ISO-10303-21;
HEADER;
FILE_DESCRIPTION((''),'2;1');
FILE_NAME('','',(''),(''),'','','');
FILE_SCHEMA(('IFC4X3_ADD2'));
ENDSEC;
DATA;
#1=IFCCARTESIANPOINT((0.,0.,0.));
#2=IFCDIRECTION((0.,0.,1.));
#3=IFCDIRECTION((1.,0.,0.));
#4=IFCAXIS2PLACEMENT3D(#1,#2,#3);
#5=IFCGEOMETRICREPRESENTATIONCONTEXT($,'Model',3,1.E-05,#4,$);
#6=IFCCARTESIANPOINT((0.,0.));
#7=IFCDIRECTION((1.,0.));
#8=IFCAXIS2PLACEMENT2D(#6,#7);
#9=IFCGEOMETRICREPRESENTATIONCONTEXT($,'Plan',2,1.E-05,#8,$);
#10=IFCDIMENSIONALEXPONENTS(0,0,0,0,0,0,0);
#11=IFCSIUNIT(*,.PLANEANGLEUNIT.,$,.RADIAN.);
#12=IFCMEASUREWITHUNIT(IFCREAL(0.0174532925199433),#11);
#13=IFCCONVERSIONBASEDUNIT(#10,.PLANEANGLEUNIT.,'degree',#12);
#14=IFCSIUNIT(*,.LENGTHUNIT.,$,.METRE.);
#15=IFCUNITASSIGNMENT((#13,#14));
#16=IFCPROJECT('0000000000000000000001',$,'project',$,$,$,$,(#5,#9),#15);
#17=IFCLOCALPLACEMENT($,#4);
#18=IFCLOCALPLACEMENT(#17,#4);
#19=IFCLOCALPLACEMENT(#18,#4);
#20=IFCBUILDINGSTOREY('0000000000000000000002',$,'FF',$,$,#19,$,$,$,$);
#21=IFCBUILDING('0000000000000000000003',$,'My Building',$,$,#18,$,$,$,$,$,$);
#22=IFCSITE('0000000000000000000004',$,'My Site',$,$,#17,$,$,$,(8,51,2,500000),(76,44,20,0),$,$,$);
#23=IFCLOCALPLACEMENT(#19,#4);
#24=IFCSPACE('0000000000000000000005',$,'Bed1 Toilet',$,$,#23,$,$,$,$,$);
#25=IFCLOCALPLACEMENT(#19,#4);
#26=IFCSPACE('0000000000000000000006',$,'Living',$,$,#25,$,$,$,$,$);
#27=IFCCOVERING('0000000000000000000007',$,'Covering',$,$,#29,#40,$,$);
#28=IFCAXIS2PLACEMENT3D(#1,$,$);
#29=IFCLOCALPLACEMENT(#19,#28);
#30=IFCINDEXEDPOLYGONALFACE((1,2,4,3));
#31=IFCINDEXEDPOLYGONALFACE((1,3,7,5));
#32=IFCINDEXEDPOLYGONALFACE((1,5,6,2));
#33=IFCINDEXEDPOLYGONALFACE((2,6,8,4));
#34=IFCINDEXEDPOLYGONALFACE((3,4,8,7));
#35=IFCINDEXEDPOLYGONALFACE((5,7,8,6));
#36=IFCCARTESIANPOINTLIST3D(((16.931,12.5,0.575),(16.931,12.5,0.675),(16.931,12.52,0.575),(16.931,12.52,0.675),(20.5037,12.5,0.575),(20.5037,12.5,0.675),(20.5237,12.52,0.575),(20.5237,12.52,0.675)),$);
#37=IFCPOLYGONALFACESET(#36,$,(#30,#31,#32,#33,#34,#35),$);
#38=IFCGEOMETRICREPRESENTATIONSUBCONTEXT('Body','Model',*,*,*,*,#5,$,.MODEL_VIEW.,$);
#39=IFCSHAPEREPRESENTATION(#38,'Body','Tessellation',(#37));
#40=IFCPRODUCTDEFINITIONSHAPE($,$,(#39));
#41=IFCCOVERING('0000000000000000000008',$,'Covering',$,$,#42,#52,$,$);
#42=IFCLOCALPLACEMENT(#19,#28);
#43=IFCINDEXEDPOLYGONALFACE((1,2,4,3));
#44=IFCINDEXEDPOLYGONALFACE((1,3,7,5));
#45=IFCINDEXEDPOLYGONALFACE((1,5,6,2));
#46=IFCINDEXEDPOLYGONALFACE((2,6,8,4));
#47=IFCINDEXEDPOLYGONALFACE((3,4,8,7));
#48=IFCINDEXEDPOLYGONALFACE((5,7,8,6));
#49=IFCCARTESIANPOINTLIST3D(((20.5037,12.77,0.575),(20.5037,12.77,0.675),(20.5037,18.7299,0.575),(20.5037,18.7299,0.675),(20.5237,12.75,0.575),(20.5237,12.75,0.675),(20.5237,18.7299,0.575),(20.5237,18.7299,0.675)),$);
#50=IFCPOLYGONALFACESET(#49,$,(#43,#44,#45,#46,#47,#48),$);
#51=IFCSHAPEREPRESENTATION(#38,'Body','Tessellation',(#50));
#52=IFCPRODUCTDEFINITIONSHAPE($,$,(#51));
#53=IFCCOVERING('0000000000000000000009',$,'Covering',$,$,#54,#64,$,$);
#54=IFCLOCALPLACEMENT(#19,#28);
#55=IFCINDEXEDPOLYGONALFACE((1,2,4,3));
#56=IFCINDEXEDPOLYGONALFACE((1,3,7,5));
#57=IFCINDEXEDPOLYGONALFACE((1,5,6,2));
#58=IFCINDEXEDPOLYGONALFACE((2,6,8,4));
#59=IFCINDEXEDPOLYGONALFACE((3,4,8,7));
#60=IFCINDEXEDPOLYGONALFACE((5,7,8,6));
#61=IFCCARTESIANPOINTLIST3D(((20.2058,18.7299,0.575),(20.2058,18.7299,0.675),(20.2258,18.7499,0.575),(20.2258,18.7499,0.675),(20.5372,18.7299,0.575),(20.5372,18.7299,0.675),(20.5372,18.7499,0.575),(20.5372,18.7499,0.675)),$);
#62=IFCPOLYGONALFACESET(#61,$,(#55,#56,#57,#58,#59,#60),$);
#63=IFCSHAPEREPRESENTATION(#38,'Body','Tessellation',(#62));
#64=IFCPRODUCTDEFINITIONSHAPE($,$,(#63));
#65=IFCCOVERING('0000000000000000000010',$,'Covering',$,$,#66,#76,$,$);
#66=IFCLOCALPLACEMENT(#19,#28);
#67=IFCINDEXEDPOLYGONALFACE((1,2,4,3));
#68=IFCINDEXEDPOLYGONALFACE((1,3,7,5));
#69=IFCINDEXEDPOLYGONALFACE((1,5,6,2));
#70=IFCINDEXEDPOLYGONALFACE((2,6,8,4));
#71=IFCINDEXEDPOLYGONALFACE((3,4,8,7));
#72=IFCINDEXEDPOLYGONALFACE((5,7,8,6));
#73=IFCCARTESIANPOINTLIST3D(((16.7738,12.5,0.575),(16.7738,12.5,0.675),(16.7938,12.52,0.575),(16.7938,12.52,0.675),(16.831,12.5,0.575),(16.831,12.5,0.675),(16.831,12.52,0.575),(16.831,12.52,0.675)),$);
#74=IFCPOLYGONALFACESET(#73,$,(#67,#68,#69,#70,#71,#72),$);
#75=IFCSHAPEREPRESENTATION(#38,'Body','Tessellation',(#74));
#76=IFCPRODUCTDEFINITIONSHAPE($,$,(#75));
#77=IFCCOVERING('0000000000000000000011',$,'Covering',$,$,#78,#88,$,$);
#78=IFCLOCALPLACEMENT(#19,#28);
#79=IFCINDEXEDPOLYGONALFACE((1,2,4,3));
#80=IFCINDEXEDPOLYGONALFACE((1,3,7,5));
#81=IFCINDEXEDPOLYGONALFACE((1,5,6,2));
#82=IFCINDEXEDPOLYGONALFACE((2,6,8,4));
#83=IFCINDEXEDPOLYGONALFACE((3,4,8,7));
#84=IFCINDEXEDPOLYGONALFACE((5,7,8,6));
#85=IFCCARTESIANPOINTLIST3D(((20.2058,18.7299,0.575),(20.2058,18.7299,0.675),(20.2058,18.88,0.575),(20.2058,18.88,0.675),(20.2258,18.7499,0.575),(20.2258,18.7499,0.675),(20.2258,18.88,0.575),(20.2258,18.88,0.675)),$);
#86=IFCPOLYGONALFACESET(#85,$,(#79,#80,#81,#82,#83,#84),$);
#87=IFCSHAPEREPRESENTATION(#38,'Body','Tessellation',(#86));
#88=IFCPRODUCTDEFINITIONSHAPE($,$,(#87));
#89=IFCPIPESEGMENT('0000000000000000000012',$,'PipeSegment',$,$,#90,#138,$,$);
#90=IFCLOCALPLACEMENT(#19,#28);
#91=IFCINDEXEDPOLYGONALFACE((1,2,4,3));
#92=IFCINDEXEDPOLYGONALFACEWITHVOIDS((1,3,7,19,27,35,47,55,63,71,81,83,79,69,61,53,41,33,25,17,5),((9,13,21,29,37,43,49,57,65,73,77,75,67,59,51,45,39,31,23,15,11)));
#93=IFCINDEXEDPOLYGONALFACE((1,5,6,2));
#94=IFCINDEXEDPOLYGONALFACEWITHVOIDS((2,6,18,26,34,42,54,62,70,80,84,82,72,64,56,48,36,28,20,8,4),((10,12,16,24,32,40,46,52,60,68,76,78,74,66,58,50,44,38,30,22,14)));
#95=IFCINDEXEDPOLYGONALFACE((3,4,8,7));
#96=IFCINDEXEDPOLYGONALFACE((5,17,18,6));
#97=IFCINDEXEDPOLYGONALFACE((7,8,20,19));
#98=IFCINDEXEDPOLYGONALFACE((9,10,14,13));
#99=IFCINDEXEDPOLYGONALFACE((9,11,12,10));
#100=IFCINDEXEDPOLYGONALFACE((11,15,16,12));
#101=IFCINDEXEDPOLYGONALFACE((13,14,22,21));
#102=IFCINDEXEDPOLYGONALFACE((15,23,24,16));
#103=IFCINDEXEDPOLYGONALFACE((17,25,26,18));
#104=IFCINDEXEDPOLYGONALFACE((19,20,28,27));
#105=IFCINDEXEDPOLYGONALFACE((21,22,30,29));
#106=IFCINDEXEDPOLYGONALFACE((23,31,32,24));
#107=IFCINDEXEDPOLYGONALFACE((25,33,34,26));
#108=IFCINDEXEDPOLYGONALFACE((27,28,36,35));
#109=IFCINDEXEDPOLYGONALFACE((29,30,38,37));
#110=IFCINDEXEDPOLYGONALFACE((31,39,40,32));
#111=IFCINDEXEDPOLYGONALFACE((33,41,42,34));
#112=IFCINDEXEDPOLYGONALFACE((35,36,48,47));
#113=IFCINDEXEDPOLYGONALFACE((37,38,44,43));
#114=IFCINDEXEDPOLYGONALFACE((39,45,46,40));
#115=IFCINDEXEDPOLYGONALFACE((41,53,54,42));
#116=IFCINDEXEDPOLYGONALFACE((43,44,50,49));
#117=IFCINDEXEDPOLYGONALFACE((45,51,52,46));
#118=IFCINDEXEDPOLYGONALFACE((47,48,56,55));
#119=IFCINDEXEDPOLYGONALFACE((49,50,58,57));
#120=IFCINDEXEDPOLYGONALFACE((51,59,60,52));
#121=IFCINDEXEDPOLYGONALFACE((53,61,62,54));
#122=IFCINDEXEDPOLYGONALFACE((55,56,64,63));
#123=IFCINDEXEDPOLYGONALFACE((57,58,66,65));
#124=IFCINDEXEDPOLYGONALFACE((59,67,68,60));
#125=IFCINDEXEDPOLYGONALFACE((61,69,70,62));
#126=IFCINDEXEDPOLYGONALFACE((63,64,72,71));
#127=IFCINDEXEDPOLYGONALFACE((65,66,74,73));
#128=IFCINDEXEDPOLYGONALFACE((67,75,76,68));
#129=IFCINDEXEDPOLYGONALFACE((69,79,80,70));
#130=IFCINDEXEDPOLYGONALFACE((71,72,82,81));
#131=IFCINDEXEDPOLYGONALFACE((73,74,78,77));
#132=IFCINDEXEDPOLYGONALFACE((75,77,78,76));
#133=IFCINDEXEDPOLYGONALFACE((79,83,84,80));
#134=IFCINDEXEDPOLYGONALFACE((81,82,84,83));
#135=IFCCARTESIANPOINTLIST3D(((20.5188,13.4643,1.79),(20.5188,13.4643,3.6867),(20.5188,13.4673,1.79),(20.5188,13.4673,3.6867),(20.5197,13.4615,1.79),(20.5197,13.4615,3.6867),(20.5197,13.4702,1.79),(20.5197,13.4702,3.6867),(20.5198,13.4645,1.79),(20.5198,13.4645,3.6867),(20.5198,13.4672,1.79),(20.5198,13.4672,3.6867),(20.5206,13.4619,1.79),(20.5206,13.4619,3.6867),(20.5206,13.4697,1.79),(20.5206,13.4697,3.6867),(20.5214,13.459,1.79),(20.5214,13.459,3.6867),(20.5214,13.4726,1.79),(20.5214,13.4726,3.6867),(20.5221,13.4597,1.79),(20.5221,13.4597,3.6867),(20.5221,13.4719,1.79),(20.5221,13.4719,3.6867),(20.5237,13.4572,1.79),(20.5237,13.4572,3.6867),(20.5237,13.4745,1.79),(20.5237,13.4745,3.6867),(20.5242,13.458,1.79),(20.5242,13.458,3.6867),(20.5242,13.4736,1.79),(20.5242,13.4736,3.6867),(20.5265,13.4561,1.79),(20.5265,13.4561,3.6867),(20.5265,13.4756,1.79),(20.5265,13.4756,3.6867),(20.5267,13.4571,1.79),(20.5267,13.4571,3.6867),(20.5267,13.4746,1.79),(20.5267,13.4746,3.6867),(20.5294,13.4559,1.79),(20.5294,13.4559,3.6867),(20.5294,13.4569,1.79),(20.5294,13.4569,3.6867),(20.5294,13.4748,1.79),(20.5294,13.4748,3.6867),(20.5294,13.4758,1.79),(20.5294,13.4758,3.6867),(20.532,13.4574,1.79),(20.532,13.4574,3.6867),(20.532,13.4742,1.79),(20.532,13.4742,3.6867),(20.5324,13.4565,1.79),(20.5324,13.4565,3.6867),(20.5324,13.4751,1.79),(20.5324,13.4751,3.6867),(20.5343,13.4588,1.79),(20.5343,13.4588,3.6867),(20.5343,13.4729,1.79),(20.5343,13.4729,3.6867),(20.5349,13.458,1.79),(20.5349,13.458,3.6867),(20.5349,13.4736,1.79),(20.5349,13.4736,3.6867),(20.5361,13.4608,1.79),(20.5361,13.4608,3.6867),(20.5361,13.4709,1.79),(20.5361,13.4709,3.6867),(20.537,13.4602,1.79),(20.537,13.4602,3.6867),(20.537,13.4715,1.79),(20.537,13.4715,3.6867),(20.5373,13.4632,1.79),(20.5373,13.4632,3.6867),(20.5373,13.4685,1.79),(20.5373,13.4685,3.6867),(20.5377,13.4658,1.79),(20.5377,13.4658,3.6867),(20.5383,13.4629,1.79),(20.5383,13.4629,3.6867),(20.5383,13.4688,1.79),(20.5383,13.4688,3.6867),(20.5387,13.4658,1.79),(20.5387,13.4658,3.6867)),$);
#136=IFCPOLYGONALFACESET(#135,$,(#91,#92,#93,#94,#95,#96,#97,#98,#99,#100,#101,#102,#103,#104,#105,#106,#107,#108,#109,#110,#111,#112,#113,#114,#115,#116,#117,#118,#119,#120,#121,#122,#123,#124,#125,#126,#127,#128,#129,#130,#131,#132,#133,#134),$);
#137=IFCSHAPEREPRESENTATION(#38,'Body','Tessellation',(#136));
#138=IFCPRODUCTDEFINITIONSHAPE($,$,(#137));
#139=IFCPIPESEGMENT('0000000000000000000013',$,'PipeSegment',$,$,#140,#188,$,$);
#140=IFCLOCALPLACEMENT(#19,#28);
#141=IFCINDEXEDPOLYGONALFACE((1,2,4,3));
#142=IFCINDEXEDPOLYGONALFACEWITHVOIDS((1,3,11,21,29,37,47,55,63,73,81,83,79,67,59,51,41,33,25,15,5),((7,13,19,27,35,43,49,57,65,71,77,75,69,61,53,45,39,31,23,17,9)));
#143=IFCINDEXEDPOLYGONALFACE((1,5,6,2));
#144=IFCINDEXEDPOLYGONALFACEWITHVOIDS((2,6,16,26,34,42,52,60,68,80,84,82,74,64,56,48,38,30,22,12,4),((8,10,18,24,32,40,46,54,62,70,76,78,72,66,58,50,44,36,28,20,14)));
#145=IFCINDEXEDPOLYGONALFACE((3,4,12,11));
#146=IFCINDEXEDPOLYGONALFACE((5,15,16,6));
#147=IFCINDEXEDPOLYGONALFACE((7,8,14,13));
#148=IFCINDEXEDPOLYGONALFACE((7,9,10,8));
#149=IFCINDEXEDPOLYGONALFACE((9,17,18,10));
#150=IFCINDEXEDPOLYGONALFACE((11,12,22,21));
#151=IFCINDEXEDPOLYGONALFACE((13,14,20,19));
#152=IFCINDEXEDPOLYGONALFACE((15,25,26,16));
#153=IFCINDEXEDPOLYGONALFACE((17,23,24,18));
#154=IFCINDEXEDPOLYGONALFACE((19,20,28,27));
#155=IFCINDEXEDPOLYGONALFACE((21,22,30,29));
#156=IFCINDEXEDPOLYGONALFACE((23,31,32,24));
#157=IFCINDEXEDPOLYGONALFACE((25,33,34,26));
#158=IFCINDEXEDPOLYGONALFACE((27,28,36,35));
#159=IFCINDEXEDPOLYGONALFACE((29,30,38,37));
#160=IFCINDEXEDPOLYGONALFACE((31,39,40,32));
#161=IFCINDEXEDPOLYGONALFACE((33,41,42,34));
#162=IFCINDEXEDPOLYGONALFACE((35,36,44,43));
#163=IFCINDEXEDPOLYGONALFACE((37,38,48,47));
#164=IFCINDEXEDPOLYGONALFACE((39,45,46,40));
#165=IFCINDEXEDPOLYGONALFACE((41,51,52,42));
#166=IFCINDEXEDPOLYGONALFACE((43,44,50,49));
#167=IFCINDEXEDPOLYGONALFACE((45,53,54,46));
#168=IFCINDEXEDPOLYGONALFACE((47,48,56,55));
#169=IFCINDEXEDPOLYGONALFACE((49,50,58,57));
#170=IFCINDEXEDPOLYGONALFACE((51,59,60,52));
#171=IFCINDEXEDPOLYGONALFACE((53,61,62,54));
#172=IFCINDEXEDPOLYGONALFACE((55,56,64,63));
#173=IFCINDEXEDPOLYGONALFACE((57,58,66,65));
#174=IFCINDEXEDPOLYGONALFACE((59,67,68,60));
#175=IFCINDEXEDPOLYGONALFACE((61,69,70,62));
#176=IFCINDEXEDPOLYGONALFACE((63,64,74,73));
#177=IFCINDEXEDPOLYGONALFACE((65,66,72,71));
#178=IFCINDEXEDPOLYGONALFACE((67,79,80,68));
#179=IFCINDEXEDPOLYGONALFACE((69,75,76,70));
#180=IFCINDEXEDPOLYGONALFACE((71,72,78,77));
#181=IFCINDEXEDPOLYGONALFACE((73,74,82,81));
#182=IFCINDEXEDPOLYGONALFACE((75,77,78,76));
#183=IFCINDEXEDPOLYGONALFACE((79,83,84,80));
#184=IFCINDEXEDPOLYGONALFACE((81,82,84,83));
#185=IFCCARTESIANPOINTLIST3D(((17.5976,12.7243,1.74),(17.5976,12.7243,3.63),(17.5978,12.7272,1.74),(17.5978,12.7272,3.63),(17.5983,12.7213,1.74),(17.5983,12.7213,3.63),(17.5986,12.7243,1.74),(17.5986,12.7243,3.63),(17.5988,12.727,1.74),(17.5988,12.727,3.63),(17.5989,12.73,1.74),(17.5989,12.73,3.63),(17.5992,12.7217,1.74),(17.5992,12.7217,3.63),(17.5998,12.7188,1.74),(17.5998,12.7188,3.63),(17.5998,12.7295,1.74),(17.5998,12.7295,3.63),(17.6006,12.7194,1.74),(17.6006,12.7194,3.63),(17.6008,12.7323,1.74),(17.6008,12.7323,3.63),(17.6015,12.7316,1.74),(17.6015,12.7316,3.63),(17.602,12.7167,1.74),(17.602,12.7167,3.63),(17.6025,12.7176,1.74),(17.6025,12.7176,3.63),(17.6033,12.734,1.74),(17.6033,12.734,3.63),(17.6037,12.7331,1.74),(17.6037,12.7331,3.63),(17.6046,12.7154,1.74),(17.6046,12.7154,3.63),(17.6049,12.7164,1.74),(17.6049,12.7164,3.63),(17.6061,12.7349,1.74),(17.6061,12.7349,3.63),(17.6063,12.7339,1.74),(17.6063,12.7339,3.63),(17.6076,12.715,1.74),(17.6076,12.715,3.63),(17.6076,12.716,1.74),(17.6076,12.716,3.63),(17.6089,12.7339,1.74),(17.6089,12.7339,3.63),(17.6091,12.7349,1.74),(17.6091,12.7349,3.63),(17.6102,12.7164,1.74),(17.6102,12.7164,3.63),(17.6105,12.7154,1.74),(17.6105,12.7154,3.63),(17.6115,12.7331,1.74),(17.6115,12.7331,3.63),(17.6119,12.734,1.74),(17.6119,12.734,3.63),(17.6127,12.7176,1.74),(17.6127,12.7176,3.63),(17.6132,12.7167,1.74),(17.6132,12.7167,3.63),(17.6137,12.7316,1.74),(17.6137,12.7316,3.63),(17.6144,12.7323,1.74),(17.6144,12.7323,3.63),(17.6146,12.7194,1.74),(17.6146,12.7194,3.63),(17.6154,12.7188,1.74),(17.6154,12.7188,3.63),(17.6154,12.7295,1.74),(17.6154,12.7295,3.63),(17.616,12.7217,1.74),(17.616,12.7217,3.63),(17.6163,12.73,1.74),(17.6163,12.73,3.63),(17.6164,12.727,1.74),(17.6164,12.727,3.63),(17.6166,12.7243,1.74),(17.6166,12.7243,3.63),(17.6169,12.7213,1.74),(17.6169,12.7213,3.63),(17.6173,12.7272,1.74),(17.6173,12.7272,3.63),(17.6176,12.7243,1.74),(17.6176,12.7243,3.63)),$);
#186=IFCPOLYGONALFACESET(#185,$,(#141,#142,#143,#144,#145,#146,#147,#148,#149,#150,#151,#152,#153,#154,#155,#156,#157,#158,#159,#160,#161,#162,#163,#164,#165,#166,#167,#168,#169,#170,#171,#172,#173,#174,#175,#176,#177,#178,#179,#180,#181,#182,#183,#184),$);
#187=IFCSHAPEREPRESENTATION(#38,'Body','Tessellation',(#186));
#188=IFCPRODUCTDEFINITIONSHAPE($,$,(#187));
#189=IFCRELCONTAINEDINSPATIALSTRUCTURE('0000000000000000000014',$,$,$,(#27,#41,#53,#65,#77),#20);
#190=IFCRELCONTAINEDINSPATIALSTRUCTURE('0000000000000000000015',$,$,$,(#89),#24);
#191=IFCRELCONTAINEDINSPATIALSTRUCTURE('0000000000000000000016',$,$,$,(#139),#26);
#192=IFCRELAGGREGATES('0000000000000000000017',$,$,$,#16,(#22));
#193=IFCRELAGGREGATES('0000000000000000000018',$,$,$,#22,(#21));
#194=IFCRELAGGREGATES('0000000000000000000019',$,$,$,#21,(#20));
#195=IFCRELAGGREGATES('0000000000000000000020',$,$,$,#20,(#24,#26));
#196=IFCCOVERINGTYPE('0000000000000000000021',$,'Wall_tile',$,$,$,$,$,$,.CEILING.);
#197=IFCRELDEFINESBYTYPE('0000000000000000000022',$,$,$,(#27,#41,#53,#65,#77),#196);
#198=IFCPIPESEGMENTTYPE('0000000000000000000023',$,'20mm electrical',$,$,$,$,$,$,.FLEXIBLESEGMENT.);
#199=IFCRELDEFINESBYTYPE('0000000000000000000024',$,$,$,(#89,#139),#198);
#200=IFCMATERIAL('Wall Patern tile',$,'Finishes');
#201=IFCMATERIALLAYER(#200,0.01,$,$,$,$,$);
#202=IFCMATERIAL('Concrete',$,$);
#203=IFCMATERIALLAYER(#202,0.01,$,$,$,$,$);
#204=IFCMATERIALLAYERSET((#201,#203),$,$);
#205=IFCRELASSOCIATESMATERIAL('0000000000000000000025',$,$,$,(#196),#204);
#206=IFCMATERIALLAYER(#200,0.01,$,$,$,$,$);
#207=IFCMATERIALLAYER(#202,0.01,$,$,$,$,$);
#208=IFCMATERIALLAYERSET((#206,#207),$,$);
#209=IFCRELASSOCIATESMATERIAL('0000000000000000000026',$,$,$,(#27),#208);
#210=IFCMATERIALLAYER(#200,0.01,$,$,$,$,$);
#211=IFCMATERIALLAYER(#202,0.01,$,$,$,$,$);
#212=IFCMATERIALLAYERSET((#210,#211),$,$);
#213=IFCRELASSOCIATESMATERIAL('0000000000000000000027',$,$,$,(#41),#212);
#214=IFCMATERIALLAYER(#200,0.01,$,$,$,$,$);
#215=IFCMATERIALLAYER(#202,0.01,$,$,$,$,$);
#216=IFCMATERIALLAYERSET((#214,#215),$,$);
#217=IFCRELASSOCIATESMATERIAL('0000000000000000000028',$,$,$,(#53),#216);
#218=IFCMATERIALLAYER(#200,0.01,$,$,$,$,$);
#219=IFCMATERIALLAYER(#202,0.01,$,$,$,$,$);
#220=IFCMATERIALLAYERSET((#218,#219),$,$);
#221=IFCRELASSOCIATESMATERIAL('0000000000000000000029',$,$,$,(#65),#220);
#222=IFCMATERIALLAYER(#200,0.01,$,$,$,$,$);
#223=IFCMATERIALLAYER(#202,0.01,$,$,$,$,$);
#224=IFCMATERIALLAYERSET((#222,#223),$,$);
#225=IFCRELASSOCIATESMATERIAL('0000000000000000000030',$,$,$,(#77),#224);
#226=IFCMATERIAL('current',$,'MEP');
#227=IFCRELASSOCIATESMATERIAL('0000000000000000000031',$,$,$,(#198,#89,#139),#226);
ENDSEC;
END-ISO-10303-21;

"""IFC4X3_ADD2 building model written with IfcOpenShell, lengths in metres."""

from ifc_helpers import new_model, entity, si_unit, converted_unit, frame, origin_with_axes, origin_2d_with_axis, place, context, subcontext, project, spatial, line, indexed_curve, hollow_circle, outline, extrude, material, layer, layer_set, layer_usage, material_profile, profile_set, profile_usage, type_object, element, save


model = new_model("IFC4X3_ADD2")

# Units and contexts
model_context = context("Model", 3, precision=1e-05, world=origin_with_axes())
plan_context = context("Plan", 2, precision=1e-05, world=origin_2d_with_axis())
body_context_1 = subcontext(model_context, "Body", "Model", "MODEL_VIEW")
ifc_project = project(units=[converted_unit("PLANEANGLEUNIT", "degree", entity("IfcReal", 0.0174532925199433), si_unit("PLANEANGLEUNIT", "RADIAN"), dimensions=[0, 0, 0, 0, 0, 0, 0]), si_unit("LENGTHUNIT", "METRE")], contexts=[model_context, plan_context])

# Site, building, storey
site_placement = place(None, origin_with_axes())
site = spatial("IfcSite", under=ifc_project, at=site_placement, Name="My Site", RefLatitude=(8, 51, 2, 500000), RefLongitude=(76, 44, 20, 0))
building_placement = place(site_placement, origin_with_axes())
building = spatial("IfcBuilding", under=site, at=building_placement, Name="My Building")
storey_placement = place(building_placement, origin_with_axes())
storey = spatial("IfcBuildingStorey", under=building, at=storey_placement, Name="FF")

# Coverings
ifc_material_1 = material(Name="Wall Patern tile", Category="Finishes")
ifc_material_2 = material(Name="Concrete")
ifc_layer_1 = layer(ifc_material_1, 0.01)
ifc_layer_2 = layer(ifc_material_2, 0.01)
ifc_layer_set_1 = layer_set([ifc_layer_1, ifc_layer_2])
covering_type = type_object("IfcCoveringType", Name="Wall_tile", PredefinedType="CEILING", material=ifc_layer_set_1)
ifc_layer_3 = layer(ifc_material_1, 0.01)
ifc_layer_4 = layer(ifc_material_2, 0.01)
ifc_layer_set_2 = layer_set([ifc_layer_3, ifc_layer_4])
ifc_layer_usage_1 = layer_usage(ifc_layer_set_2, "AXIS2", "POSITIVE", 0.0)
covering_1_placement = place(storey_placement, frame((16.931, 12.5, 0.575), z_axis=(0.0, 0.0, 1.0), x_axis=(1.0, 0.0, 0.0)))
element("IfcCovering", 1, at=covering_1_placement, inside=storey, type_object=covering_type, material=ifc_layer_usage_1, Name="Covering", context=body_context_1, shape_type="SweptSolid", body=[
    extrude(outline(indexed_curve([(0.0, 0.0), (0.0, 0.02), (3.5927, 0.02), (3.5727, 0.0)], segments=[line(1, 2, 3, 4, 1)])), origin_with_axes(), (0.0, 0.0, 1.0), 0.1),
])
ifc_layer_5 = layer(ifc_material_1, 0.01)
ifc_layer_6 = layer(ifc_material_2, 0.01)
ifc_layer_set_3 = layer_set([ifc_layer_5, ifc_layer_6])
ifc_layer_usage_2 = layer_usage(ifc_layer_set_3, "AXIS2", "POSITIVE", 0.0)
covering_2_placement = place(storey_placement, frame((20.5037, 18.7299, 0.575), z_axis=(0.0, 0.0, 1.0), x_axis=(0.0, -1.0, 0.0)))
element("IfcCovering", 2, at=covering_2_placement, inside=storey, type_object=covering_type, material=ifc_layer_usage_2, Name="Covering", context=body_context_1, shape_type="SweptSolid", body=[
    extrude(outline(indexed_curve([(0.0, 0.0), (0.0, 0.02), (5.9799, 0.02), (5.9599, 0.0)], segments=[line(1, 2, 3, 4, 1)])), origin_with_axes(), (0.0, 0.0, 1.0), 0.1),
])
ifc_layer_7 = layer(ifc_material_1, 0.01)
ifc_layer_8 = layer(ifc_material_2, 0.01)
ifc_layer_set_4 = layer_set([ifc_layer_7, ifc_layer_8])
ifc_layer_usage_3 = layer_usage(ifc_layer_set_4, "AXIS2", "POSITIVE", 0.0)
covering_3_placement = place(storey_placement, frame((20.2258, 18.7299, 0.575), z_axis=(0.0, 0.0, 1.0), x_axis=(1.0, 0.0, 0.0)))
element("IfcCovering", 3, at=covering_3_placement, inside=storey, type_object=covering_type, material=ifc_layer_usage_3, Name="Covering", context=body_context_1, shape_type="SweptSolid", body=[
    extrude(outline(indexed_curve([(-0.02, 0.0), (0.0, 0.02), (0.3114, 0.02), (0.3114, 0.0)], segments=[line(1, 2, 3, 4, 1)])), origin_with_axes(), (0.0, 0.0, 1.0), 0.1),
])
ifc_layer_9 = layer(ifc_material_1, 0.01)
ifc_layer_10 = layer(ifc_material_2, 0.01)
ifc_layer_set_5 = layer_set([ifc_layer_9, ifc_layer_10])
ifc_layer_usage_4 = layer_usage(ifc_layer_set_5, "AXIS2", "POSITIVE", 0.0)
covering_4_placement = place(storey_placement, frame((16.7738, 12.5, 0.575), z_axis=(0.0, 0.0, 1.0), x_axis=(1.0, 0.0, 0.0)))
element("IfcCovering", 4, at=covering_4_placement, inside=storey, type_object=covering_type, material=ifc_layer_usage_4, Name="Covering", context=body_context_1, shape_type="SweptSolid", body=[
    extrude(outline(indexed_curve([(0.0, 0.0), (0.02, 0.02), (0.0572, 0.02), (0.0572, 0.0)], segments=[line(1, 2, 3, 4, 1)])), origin_with_axes(), (0.0, 0.0, 1.0), 0.1),
])
ifc_layer_11 = layer(ifc_material_1, 0.01)
ifc_layer_12 = layer(ifc_material_2, 0.01)
ifc_layer_set_6 = layer_set([ifc_layer_11, ifc_layer_12])
ifc_layer_usage_5 = layer_usage(ifc_layer_set_6, "AXIS2", "NEGATIVE", 0.0)
covering_5_placement = place(storey_placement, frame((20.2058, 18.7299, 0.575), z_axis=(0.0, 0.0, 1.0), x_axis=(0.0, 1.0, 0.0)))
element("IfcCovering", 5, at=covering_5_placement, inside=storey, type_object=covering_type, material=ifc_layer_usage_5, Name="Covering", context=body_context_1, shape_type="SweptSolid", body=[
    extrude(outline(indexed_curve([(0.02, -0.02), (0.0, 0.0), (0.1501, 0.0), (0.1501, -0.02)], segments=[line(1, 2, 3, 4, 1)])), origin_with_axes(), (0.0, 0.0, 1.0), 0.1),
])

# Shared definitions
space_1_placement = place(storey_placement, origin_with_axes())
space_1 = spatial("IfcSpace", under=storey, at=space_1_placement, Name="Bed1 Toilet")

# Pipe segment
ifc_material_3 = material(Name="current", Category="MEP")
ifc_material_profile_1 = material_profile(ifc_material_3, hollow_circle(Radius=0.01, WallThickness=0.001))
ifc_profile_set_1 = profile_set([ifc_material_profile_1], Name="current")
ifc_profile_usage_1 = profile_usage(ifc_profile_set_1, cardinal=5)
pipe_segment_type = type_object("IfcPipeSegmentType", Name="20mm electrical", PredefinedType="FLEXIBLESEGMENT", material=ifc_profile_set_1)
pipe_segment_1_placement = place(space_1_placement, frame((20.5287, 13.4658, 1.79), z_axis=(0.0, 0.0, 1.0), x_axis=(1.0, 0.0, 0.0)))
element("IfcPipeSegment", 6, at=pipe_segment_1_placement, inside=space_1, type_object=pipe_segment_type, material=ifc_profile_usage_1, Name="PipeSegment", context=body_context_1, shape_type="SweptSolid", body=[
    extrude(hollow_circle(Radius=0.01, WallThickness=0.001), origin_with_axes(), (0.0, 0.0, 1.0), 1.8967),
])

# Shared definitions
space_2_placement = place(storey_placement, origin_with_axes())
space_2 = spatial("IfcSpace", under=storey, at=space_2_placement, Name="Living")

# Pipe segment
ifc_profile_usage_2 = profile_usage(ifc_profile_set_1, cardinal=5)
pipe_segment_2_placement = place(space_2_placement, frame((17.6076, 12.725, 1.74), z_axis=(0.0, 0.0, 1.0), x_axis=(0.0, -1.0, 0.0)))
element("IfcPipeSegment", 7, at=pipe_segment_2_placement, inside=space_2, type_object=pipe_segment_type, material=ifc_profile_usage_2, Name="PipeSegment", context=body_context_1, shape_type="SweptSolid", body=[
    extrude(hollow_circle(Radius=0.01, WallThickness=0.001), origin_with_axes(), (0.0, 0.0, 1.0), 1.89),
])

save(model, "model.ifc")
